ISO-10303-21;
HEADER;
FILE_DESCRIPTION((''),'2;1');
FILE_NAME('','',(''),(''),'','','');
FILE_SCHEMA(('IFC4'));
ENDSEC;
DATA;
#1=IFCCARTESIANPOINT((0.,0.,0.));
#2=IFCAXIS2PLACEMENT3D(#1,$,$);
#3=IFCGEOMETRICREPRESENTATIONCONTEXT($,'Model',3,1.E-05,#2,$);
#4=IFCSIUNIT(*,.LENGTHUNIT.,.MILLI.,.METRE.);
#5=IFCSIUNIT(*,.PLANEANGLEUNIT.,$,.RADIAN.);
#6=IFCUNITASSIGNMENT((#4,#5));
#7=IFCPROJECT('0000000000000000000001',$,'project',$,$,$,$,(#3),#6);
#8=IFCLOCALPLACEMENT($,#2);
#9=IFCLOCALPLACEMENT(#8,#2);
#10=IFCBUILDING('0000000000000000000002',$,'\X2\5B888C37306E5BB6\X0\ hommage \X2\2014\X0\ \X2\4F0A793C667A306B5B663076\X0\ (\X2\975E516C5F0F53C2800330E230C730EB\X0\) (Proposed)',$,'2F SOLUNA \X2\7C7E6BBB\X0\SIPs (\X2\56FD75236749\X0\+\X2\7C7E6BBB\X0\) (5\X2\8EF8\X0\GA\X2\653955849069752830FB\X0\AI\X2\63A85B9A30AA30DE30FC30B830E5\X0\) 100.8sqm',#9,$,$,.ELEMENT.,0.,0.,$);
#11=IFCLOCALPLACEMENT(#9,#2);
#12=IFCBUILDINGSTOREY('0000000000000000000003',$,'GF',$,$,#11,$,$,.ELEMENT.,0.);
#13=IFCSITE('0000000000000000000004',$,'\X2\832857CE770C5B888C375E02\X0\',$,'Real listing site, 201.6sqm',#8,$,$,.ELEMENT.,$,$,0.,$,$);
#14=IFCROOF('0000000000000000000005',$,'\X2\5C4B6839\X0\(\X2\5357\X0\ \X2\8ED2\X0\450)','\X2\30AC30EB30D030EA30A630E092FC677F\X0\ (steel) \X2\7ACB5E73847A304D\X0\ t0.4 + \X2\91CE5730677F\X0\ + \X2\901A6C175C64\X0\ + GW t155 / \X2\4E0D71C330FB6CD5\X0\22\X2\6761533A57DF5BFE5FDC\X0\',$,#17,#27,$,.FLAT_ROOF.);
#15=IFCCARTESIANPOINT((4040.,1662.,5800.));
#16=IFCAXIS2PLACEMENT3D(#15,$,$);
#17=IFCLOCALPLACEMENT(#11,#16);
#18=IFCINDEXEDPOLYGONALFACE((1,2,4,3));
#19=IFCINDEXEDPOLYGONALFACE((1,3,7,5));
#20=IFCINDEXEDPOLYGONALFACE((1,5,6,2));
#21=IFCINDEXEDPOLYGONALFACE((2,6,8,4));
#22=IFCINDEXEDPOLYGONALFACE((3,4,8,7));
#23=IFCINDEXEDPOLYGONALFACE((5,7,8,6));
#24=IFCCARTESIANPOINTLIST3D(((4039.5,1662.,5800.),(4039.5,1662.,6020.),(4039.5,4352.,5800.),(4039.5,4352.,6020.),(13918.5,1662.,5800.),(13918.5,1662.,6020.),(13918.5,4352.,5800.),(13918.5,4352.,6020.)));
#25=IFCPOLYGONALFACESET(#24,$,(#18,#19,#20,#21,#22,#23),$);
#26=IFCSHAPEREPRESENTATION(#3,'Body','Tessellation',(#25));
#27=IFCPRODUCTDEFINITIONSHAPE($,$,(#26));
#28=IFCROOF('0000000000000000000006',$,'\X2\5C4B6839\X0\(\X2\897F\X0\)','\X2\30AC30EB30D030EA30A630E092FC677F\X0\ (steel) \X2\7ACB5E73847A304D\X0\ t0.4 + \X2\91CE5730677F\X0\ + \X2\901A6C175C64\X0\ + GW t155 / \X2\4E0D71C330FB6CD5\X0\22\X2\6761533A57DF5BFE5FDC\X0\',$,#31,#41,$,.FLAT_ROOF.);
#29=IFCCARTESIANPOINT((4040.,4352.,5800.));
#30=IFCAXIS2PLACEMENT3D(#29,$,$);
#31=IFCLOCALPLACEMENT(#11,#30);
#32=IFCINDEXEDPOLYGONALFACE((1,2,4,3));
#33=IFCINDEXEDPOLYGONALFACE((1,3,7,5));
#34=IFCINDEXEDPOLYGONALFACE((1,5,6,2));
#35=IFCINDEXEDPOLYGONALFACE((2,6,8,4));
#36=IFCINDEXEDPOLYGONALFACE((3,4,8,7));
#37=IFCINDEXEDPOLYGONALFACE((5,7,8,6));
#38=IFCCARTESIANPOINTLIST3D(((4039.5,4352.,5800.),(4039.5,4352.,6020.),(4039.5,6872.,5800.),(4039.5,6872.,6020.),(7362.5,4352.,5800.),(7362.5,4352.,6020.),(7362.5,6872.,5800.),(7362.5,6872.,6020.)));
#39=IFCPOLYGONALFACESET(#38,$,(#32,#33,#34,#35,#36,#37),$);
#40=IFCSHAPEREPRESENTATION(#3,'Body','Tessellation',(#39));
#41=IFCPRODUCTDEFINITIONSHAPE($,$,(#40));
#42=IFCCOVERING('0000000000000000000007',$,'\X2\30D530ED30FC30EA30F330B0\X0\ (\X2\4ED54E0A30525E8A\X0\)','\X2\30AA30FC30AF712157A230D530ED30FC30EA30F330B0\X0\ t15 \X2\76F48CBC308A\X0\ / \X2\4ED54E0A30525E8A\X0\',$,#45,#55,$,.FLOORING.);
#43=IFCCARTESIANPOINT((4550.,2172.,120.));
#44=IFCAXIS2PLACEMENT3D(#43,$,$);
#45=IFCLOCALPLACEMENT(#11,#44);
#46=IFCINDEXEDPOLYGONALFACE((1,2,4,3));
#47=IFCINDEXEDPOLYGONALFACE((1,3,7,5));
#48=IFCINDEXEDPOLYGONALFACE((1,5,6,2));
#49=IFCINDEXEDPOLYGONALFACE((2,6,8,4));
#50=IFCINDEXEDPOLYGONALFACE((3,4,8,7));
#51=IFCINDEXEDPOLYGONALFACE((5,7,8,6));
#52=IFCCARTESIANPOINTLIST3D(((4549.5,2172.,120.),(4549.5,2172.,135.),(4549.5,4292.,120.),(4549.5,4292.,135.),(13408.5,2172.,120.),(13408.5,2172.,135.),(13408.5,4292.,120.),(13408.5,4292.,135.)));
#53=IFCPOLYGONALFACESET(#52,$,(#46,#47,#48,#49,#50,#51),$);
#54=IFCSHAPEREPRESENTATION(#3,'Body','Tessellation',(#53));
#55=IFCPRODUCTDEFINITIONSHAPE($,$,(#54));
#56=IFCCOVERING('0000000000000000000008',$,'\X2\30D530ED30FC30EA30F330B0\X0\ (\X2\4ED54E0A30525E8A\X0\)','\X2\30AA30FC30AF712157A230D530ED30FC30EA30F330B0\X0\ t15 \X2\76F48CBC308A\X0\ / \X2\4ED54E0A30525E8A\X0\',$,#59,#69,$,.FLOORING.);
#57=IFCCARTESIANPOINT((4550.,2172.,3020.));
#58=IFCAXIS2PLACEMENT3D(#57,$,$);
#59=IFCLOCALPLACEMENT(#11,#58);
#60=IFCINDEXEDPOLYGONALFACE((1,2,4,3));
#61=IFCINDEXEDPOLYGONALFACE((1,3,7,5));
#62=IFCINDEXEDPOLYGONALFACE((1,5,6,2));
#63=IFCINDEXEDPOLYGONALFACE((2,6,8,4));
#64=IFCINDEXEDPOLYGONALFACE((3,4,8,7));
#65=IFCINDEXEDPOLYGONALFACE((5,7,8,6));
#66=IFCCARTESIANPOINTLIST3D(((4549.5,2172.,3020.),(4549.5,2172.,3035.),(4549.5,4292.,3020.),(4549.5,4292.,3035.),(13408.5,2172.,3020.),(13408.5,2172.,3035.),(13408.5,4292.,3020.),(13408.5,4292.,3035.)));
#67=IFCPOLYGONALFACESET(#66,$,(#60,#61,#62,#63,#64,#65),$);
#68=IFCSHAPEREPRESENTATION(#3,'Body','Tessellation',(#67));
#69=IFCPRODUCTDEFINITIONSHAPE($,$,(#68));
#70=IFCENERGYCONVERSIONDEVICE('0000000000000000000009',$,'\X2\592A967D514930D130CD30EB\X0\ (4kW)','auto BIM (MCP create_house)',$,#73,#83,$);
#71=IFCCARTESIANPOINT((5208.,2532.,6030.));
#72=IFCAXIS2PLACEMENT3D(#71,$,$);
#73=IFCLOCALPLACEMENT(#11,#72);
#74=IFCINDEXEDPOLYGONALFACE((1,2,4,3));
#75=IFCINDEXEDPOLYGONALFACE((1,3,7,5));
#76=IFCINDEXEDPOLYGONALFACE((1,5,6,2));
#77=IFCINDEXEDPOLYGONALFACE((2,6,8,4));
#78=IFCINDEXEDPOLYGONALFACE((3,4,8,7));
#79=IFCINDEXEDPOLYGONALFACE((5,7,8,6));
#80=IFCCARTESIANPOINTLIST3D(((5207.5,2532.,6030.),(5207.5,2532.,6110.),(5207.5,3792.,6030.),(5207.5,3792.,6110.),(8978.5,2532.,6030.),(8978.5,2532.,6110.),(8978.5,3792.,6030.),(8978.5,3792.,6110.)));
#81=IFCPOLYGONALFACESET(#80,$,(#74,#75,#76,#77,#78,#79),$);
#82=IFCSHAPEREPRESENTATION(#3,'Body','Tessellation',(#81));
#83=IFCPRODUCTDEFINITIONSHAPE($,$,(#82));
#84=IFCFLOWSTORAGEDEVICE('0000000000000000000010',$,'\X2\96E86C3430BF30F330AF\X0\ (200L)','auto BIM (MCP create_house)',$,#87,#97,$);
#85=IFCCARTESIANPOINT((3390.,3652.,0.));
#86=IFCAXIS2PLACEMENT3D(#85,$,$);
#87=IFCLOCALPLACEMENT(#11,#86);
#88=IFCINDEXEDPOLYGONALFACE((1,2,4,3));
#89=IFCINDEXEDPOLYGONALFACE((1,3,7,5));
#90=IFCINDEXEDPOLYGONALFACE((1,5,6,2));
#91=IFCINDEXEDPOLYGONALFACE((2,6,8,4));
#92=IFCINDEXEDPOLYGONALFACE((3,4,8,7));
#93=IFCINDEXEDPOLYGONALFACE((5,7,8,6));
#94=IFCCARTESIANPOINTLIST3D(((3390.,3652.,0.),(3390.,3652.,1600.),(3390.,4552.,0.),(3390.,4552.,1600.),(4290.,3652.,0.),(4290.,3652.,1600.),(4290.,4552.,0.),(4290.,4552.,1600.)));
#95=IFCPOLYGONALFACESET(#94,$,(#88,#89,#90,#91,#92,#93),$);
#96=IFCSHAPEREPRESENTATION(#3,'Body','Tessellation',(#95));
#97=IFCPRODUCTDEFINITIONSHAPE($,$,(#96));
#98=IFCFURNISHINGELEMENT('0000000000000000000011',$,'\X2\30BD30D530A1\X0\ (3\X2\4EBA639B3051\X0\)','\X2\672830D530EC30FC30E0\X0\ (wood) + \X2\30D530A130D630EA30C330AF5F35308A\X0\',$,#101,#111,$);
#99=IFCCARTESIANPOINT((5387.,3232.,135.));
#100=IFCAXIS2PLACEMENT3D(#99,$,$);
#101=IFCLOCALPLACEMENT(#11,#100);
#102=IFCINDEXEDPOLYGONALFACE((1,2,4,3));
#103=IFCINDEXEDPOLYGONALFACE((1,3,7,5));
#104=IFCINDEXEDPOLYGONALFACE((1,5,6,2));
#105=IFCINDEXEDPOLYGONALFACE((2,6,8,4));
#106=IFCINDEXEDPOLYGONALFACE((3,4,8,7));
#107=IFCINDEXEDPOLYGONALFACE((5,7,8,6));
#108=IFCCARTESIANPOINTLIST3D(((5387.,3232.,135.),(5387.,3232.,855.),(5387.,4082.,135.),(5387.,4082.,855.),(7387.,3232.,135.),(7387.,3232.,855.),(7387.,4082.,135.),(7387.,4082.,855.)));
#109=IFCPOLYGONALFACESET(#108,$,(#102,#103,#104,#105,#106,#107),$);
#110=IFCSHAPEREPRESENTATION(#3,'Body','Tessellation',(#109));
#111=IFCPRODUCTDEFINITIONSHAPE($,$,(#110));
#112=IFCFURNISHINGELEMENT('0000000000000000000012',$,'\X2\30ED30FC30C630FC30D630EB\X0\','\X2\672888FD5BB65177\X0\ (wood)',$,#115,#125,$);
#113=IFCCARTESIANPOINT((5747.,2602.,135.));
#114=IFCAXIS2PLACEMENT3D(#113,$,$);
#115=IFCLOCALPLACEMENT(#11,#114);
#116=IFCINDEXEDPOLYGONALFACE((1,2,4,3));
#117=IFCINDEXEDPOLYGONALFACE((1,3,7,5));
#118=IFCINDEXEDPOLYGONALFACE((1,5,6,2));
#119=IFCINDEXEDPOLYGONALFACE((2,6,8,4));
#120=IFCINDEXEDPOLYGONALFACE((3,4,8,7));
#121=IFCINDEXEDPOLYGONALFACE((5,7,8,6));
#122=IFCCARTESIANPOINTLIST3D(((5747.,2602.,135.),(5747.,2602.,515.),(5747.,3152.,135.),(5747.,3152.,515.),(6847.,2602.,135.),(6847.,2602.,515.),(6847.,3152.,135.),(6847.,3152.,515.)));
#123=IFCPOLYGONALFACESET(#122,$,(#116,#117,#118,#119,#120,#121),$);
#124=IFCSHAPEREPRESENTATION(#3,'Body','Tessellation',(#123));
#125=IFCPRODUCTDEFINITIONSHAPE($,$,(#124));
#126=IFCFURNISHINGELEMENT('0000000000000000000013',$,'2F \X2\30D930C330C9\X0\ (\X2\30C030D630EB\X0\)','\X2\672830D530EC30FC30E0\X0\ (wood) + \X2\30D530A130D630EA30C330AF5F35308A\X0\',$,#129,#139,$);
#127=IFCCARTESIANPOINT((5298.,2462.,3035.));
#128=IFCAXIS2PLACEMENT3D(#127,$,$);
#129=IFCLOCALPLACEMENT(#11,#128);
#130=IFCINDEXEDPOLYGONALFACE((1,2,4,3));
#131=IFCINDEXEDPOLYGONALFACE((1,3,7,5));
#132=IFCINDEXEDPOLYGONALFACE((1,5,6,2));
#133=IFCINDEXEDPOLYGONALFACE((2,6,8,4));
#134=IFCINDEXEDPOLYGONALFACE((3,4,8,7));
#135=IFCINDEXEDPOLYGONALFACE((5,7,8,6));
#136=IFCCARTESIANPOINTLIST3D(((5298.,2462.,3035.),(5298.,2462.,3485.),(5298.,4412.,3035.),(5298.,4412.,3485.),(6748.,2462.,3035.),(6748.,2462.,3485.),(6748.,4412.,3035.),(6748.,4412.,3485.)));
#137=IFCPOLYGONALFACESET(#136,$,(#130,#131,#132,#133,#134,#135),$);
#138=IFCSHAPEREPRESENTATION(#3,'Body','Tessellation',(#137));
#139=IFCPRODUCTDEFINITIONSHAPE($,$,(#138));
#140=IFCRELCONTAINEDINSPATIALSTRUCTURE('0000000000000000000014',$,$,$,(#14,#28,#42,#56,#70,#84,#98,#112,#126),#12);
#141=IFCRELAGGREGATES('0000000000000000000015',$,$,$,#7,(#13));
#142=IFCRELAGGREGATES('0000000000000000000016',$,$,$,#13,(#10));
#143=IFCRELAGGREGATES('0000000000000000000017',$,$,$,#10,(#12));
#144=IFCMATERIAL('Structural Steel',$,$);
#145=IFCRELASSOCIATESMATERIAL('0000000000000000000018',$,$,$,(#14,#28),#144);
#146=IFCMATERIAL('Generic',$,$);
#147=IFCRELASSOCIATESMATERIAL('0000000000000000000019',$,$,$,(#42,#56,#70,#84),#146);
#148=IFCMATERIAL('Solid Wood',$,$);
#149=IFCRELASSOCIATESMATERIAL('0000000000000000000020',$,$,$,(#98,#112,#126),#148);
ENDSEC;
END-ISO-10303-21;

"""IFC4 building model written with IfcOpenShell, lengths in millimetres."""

from ifc_helpers import new_model, si_unit, frame, frame_2d, origin, place, context, project, spatial, rectangle, extrude, material, element, save


model = new_model("IFC4")

# Units and contexts
model_context = context("Model", 3, precision=1e-05, world=origin())
ifc_project = project(units=[si_unit("LENGTHUNIT", "METRE", prefix="MILLI"), si_unit("PLANEANGLEUNIT", "RADIAN")], contexts=[model_context])

# Site, building, storey
site_placement = place(None, origin())
site = spatial("IfcSite", under=ifc_project, at=site_placement, Name="茨城県守谷市", ObjectType="Real listing site, 201.6sqm", CompositionType="ELEMENT", RefElevation=0.0)
building_placement = place(site_placement, origin())
building = spatial("IfcBuilding", under=site, at=building_placement, Name="守谷の家 hommage — 伊礼智に学ぶ (非公式参考モデル) (Proposed)", ObjectType="2F SOLUNA 籾殻SIPs (国産杉+籾殻) (5軸GA改善適用・AI推定オマージュ) 100.8sqm", CompositionType="ELEMENT", ElevationOfRefHeight=0.0, ElevationOfTerrain=0.0)
storey_placement = place(building_placement, origin())
storey = spatial("IfcBuildingStorey", under=building, at=storey_placement, Name="GF", CompositionType="ELEMENT", Elevation=0.0)

# Shared definitions
ifc_material_1 = material(Name="Solid Wood")

# Roofs
ifc_material_2 = material(Name="Structural Steel")
roof_1_placement = place(storey_placement, frame((4040.0, 1662.0, 5800.0)))
element("IfcRoof", 1, at=roof_1_placement, inside=storey, material=ifc_material_2, Name="屋根(南 軒450)", Description="ガルバリウム鋼板 (steel) 立平葺き t0.4 + 野地板 + 通気層 + GW t155 / 不燃・法22条区域対応", PredefinedType="FLAT_ROOF", context=model_context, shape_type="SweptSolid", body=[
    extrude(rectangle(XDim=9879.0, YDim=2690.0, at=frame_2d((4939.0, 1345.0))), frame((4040.0, 1662.0, 5800.0)), (0.0, 0.0, 1.0), 220.0),
])
roof_2_placement = place(storey_placement, frame((4040.0, 4352.0, 5800.0)))
element("IfcRoof", 2, at=roof_2_placement, inside=storey, material=ifc_material_2, Name="屋根(西)", Description="ガルバリウム鋼板 (steel) 立平葺き t0.4 + 野地板 + 通気層 + GW t155 / 不燃・法22条区域対応", PredefinedType="FLAT_ROOF", context=model_context, shape_type="SweptSolid", body=[
    extrude(rectangle(XDim=3323.0, YDim=2520.0, at=frame_2d((1661.0, 1260.0))), frame((4040.0, 4352.0, 5800.0)), (0.0, 0.0, 1.0), 220.0),
])

# Coverings
ifc_material_3 = material(Name="Generic")
covering_1_placement = place(storey_placement, frame((4550.0, 2172.0, 120.0)))
element("IfcCovering", 3, at=covering_1_placement, inside=storey, material=ifc_material_3, Name="フローリング (仕上げ床)", Description="オーク無垢フローリング t15 直貼り / 仕上げ床", PredefinedType="FLOORING", context=model_context, shape_type="SweptSolid", body=[
    extrude(rectangle(XDim=8859.0, YDim=2120.0, at=frame_2d((4429.0, 1060.0))), frame((4550.0, 2172.0, 120.0)), (0.0, 0.0, 1.0), 15.0),
])
covering_2_placement = place(storey_placement, frame((4550.0, 2172.0, 3020.0)))
element("IfcCovering", 4, at=covering_2_placement, inside=storey, material=ifc_material_3, Name="フローリング (仕上げ床)", Description="オーク無垢フローリング t15 直貼り / 仕上げ床", PredefinedType="FLOORING", context=model_context, shape_type="SweptSolid", body=[
    extrude(rectangle(XDim=8859.0, YDim=2120.0, at=frame_2d((4429.0, 1060.0))), frame((4550.0, 2172.0, 3020.0)), (0.0, 0.0, 1.0), 15.0),
])

# Energy conversion device
energy_conversion_device_placement = place(storey_placement, frame((5208.0, 2532.0, 6030.0)))
element("IfcEnergyConversionDevice", 5, at=energy_conversion_device_placement, inside=storey, material=ifc_material_3, Name="太陽光パネル (4kW)", Description="auto BIM (MCP create_house)", context=model_context, shape_type="SweptSolid", body=[
    extrude(rectangle(XDim=3771.0, YDim=1260.0, at=frame_2d((1885.0, 630.0))), frame((5208.0, 2532.0, 6030.0)), (0.0, 0.0, 1.0), 80.0),
])

# Flow storage device
flow_storage_device_placement = place(storey_placement, frame((3390.0, 3652.0, 0.0)))
element("IfcFlowStorageDevice", 6, at=flow_storage_device_placement, inside=storey, material=ifc_material_3, Name="雨水タンク (200L)", Description="auto BIM (MCP create_house)", context=model_context, shape_type="SweptSolid", body=[
    extrude(rectangle(XDim=900.0, YDim=900.0, at=frame_2d((450.0, 450.0))), frame((3390.0, 3652.0, 0.0)), (0.0, 0.0, 1.0), 1600.0),
])

# Furnishing elements
furnishing_1_placement = place(storey_placement, frame((5387.0, 3232.0, 135.0)))
element("IfcFurnishingElement", 7, at=furnishing_1_placement, inside=storey, material=ifc_material_1, Name="ソファ (3人掛け)", Description="木フレーム (wood) + ファブリック張り", context=model_context, shape_type="SweptSolid", body=[
    extrude(rectangle(XDim=2000.0, YDim=850.0, at=frame_2d((1000.0, 425.0))), frame((5387.0, 3232.0, 135.0)), (0.0, 0.0, 1.0), 720.0),
])
furnishing_2_placement = place(storey_placement, frame((5747.0, 2602.0, 135.0)))
element("IfcFurnishingElement", 8, at=furnishing_2_placement, inside=storey, material=ifc_material_1, Name="ローテーブル", Description="木製家具 (wood)", context=model_context, shape_type="SweptSolid", body=[
    extrude(rectangle(XDim=1100.0, YDim=550.0, at=frame_2d((550.0, 275.0))), frame((5747.0, 2602.0, 135.0)), (0.0, 0.0, 1.0), 380.0),
])
furnishing_3_placement = place(storey_placement, frame((5298.0, 2462.0, 3035.0)))
element("IfcFurnishingElement", 9, at=furnishing_3_placement, inside=storey, material=ifc_material_1, Name="2F ベッド (ダブル)", Description="木フレーム (wood) + ファブリック張り", context=model_context, shape_type="SweptSolid", body=[
    extrude(rectangle(XDim=1450.0, YDim=1950.0, at=frame_2d((725.0, 975.0))), frame((5298.0, 2462.0, 3035.0)), (0.0, 0.0, 1.0), 450.0),
])

save(model, "model.ifc")
